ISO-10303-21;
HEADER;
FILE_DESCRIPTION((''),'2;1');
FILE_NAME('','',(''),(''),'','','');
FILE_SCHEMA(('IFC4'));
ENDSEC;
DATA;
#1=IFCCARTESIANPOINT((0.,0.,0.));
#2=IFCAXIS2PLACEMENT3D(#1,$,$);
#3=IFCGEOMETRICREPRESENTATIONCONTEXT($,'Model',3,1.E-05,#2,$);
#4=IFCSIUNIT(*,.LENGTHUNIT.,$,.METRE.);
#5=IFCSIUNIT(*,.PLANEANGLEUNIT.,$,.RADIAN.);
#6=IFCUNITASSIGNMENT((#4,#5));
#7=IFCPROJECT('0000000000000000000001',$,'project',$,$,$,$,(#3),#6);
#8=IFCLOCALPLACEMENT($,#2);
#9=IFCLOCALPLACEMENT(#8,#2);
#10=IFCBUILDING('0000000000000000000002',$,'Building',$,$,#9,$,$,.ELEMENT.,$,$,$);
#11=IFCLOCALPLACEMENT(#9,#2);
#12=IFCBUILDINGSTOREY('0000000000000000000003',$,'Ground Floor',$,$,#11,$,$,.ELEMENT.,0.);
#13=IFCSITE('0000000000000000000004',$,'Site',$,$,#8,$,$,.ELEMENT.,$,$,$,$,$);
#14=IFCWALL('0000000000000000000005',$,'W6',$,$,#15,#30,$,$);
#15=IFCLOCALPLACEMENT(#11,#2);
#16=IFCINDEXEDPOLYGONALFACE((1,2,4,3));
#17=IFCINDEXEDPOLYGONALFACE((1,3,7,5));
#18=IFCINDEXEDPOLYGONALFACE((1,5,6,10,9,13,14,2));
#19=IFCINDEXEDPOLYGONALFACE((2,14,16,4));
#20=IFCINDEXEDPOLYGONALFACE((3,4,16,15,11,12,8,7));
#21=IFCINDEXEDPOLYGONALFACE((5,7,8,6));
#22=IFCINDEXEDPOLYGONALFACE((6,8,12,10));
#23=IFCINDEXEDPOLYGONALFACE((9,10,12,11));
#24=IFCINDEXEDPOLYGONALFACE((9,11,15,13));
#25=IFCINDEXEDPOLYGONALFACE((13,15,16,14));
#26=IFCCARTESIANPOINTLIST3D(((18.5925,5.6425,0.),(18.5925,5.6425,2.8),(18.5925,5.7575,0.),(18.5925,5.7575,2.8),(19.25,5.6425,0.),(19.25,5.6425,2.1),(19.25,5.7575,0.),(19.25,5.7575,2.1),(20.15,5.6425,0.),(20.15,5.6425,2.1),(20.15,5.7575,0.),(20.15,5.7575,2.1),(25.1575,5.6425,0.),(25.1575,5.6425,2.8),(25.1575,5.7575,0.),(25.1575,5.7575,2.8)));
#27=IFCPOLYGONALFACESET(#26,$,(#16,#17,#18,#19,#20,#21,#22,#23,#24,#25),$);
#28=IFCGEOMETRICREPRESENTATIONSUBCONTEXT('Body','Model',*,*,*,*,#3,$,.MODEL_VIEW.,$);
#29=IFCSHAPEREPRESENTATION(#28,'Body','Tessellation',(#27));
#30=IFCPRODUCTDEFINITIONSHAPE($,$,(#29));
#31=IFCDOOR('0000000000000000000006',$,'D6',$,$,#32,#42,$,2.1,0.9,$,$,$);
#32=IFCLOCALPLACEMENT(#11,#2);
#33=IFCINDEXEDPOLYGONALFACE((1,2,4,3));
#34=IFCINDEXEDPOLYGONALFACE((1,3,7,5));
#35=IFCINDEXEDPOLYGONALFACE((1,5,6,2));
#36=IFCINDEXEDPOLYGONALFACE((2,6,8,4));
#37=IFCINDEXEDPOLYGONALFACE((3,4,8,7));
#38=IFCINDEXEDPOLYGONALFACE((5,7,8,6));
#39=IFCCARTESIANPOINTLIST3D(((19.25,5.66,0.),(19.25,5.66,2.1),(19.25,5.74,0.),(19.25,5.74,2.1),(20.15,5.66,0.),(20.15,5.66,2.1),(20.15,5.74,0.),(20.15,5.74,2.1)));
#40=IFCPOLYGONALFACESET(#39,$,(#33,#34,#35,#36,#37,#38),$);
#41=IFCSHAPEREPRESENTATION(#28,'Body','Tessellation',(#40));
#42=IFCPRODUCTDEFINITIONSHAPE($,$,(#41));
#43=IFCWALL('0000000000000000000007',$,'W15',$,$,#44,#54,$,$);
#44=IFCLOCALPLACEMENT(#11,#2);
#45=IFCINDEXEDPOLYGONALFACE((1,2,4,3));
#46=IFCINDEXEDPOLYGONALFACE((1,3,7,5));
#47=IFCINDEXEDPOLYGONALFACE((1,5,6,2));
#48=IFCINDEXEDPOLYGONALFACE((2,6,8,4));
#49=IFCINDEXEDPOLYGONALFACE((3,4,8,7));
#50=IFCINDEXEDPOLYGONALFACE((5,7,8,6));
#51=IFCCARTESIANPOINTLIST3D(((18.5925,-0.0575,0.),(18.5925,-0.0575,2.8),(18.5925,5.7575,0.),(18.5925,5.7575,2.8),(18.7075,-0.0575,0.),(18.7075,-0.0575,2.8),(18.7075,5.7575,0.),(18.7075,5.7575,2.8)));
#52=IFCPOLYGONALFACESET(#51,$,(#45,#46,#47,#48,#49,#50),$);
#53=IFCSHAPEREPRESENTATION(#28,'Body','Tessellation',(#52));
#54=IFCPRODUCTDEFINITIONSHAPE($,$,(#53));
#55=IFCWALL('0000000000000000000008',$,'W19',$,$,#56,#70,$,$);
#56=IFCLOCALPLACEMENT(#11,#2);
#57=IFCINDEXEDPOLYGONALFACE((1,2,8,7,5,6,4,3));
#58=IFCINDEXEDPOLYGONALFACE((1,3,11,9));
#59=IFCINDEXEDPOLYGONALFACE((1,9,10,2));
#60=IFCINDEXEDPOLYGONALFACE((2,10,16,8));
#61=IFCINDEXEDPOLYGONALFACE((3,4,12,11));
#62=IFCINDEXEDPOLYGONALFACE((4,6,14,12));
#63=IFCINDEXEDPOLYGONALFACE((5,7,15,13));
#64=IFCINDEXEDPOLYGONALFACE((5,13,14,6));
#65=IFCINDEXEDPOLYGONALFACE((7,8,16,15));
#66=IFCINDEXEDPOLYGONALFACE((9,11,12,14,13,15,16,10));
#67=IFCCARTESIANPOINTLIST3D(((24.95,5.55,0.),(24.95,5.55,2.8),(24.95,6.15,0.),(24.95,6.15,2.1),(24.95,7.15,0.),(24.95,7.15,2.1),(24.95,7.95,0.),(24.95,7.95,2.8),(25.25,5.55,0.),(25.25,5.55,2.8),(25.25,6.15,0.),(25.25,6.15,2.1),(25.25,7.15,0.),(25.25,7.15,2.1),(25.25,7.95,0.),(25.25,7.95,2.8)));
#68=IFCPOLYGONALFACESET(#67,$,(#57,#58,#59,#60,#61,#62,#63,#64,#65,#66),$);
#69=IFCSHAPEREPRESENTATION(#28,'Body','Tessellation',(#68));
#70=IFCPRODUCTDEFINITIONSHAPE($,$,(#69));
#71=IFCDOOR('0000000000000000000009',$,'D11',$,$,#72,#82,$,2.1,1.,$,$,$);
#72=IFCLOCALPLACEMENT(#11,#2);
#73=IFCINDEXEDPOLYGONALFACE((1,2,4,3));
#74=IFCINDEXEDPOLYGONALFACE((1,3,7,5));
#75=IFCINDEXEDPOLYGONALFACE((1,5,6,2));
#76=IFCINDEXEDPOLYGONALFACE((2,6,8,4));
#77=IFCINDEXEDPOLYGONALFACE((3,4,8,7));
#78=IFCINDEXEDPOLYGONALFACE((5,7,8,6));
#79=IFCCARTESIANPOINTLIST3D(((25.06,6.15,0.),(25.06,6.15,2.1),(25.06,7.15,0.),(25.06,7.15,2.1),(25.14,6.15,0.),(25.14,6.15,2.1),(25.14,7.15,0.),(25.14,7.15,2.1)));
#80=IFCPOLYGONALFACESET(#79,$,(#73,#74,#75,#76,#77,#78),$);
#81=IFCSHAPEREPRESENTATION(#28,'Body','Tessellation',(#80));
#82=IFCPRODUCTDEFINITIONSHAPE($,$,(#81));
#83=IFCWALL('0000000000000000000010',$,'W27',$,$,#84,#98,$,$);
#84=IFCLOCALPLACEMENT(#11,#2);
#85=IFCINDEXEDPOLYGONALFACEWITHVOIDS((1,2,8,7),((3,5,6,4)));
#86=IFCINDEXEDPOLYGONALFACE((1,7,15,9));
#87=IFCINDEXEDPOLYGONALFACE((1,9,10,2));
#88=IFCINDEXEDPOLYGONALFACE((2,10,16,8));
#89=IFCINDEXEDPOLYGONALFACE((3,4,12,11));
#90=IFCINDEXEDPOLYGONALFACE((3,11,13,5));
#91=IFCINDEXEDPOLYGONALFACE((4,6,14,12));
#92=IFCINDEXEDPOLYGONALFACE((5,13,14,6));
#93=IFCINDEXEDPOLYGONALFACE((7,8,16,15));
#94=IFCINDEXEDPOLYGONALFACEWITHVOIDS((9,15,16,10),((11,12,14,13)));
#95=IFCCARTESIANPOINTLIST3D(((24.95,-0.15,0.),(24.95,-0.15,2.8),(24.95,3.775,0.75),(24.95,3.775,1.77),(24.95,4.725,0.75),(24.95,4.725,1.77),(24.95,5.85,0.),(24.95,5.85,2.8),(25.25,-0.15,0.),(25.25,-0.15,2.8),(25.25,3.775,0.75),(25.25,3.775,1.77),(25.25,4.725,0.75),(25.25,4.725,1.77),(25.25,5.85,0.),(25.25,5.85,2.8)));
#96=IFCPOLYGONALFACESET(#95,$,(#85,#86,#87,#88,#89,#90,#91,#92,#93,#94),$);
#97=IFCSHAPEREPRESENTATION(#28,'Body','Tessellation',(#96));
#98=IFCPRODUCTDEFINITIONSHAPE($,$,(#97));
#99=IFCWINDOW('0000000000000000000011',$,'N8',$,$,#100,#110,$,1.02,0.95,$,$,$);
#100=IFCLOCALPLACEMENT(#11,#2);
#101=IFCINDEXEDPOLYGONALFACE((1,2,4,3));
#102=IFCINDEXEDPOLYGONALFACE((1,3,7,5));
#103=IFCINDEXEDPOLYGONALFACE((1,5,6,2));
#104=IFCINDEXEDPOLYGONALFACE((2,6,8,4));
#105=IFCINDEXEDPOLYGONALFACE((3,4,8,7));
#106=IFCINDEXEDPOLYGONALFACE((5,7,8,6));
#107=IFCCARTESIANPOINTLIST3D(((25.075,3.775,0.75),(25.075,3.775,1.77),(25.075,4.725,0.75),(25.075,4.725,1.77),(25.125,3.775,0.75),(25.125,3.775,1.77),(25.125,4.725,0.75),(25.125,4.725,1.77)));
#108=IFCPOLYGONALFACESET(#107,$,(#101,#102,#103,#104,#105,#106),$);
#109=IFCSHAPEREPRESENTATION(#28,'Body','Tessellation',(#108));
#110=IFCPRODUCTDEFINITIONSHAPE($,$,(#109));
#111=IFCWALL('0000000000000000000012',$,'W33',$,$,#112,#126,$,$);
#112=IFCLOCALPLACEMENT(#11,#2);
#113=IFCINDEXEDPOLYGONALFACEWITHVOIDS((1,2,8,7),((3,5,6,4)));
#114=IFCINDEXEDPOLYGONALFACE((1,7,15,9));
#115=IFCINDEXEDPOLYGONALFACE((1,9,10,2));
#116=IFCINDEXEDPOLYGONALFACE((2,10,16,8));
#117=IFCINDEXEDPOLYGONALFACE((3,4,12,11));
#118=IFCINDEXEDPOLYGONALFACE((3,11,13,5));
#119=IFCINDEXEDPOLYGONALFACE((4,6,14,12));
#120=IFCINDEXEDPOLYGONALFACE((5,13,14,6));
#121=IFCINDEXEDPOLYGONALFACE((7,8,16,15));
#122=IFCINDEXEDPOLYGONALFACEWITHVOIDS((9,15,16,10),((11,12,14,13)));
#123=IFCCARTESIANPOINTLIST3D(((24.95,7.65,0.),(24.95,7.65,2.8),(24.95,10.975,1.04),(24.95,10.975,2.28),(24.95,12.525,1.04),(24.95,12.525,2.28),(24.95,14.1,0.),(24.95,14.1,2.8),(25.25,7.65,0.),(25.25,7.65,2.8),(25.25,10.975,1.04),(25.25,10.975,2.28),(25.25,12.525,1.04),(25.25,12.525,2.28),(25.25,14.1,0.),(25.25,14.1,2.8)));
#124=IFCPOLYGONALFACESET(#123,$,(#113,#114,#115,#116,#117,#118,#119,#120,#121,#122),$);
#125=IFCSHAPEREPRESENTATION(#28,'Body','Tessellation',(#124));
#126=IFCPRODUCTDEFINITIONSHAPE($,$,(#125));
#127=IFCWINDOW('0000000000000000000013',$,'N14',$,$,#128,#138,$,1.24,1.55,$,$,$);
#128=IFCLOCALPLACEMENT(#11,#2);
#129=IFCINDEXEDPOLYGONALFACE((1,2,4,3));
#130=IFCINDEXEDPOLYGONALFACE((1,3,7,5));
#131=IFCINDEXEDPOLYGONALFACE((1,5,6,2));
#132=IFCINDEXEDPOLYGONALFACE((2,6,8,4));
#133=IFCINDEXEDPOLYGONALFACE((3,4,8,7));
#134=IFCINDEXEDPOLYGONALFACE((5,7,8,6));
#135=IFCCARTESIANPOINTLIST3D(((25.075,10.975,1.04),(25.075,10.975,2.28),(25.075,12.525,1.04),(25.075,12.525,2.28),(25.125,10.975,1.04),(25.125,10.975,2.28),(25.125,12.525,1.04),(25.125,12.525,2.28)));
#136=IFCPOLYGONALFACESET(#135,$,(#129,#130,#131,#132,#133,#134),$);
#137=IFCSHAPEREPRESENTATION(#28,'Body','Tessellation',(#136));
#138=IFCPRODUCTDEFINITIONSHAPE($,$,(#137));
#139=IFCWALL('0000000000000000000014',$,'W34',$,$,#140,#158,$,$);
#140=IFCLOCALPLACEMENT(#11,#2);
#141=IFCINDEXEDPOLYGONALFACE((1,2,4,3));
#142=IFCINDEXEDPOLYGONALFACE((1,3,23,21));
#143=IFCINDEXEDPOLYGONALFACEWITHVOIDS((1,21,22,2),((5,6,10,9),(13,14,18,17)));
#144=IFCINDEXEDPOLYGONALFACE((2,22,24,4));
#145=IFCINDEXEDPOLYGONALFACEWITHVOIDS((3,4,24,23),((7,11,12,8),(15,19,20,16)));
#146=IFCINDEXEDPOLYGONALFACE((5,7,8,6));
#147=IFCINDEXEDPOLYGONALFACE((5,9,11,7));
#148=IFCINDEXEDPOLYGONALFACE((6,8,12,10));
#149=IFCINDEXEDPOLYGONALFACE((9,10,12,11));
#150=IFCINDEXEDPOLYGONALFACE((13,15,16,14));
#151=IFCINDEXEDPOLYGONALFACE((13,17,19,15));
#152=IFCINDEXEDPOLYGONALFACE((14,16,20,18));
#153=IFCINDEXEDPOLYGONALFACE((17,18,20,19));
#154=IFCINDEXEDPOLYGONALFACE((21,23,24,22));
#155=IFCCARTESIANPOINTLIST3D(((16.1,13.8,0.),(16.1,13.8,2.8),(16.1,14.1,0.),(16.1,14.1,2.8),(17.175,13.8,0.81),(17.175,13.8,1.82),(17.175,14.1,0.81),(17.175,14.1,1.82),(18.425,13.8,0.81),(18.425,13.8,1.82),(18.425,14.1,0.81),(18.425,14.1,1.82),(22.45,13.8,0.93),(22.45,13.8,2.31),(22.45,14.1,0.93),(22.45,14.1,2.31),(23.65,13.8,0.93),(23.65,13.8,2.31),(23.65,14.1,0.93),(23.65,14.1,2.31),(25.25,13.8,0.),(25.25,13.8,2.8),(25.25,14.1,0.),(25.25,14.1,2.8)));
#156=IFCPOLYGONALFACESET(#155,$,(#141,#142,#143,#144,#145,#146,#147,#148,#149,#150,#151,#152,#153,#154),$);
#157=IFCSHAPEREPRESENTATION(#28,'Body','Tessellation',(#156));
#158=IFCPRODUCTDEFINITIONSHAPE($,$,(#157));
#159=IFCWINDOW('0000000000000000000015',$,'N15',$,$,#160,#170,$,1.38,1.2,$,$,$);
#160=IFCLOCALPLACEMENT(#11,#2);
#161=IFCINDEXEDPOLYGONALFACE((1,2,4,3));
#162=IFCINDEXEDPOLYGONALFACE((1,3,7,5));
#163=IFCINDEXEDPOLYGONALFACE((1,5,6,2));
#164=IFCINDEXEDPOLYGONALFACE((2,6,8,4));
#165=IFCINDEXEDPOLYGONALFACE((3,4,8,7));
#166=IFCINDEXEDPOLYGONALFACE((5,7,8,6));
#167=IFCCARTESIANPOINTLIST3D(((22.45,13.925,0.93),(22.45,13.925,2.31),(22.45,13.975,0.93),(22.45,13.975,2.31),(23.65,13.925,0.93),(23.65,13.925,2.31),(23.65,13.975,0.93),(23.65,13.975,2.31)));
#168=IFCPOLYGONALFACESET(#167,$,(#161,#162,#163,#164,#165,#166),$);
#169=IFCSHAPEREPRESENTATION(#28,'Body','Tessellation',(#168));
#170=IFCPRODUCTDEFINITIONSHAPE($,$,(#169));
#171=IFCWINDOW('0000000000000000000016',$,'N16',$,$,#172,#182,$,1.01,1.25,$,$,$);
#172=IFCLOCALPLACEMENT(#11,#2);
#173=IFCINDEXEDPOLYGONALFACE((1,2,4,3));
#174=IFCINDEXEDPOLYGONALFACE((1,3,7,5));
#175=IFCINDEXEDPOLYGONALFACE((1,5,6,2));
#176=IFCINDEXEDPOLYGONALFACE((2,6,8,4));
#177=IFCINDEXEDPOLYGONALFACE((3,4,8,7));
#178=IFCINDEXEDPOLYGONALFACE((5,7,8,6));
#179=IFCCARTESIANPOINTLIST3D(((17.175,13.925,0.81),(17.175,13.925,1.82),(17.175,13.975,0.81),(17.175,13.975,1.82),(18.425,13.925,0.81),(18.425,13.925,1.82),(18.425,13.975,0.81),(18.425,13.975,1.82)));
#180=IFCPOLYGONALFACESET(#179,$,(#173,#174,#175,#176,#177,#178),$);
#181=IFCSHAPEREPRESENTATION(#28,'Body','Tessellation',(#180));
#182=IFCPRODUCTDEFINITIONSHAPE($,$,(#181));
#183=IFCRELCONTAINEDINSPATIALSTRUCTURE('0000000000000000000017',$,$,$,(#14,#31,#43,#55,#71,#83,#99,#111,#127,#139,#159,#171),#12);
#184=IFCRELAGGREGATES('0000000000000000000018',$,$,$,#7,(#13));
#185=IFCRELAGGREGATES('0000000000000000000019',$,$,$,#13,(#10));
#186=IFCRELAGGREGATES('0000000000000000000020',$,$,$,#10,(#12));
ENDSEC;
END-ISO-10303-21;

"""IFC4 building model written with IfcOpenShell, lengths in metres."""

from ifc_helpers import new_model, si_unit, frame, frame_2d, origin, origin_2d, place, context, subcontext, project, spatial, rectangle, extrude, element, fill, save


model = new_model("IFC4")

# Units and contexts
model_context = context("Model", 3, precision=1e-05, world=origin())
body_context = subcontext(model_context, "Body", "Model", "MODEL_VIEW")
ifc_project = project(units=[si_unit("LENGTHUNIT", "METRE"), si_unit("PLANEANGLEUNIT", "RADIAN")], contexts=[model_context])

# Site, building, storey
site_placement = place(None, origin())
site = spatial("IfcSite", under=ifc_project, at=site_placement, Name="Site", CompositionType="ELEMENT")
building_placement = place(site_placement, origin())
building = spatial("IfcBuilding", under=site, at=building_placement, Name="Building", CompositionType="ELEMENT")
storey_placement = place(building_placement, origin())
storey = spatial("IfcBuildingStorey", under=building, at=storey_placement, Name="Ground Floor", CompositionType="ELEMENT", Elevation=0.0)

# Wall, opening, door
wall_1_placement = place(storey_placement, frame((18.65, 5.7, 0.0), x_axis=(1.0, 0.0, 0.0)))
wall_1 = element("IfcWall", 1, at=wall_1_placement, inside=storey, Name="W6", context=body_context, shape_type="SweptSolid", body=[
    extrude(rectangle(XDim=6.565, YDim=0.115, at=frame_2d((3.225, 0.0))), origin(), (0.0, 0.0, 1.0), 2.8),
])
opening_1_placement = place(wall_1_placement, frame((1.05, 0.0, 0.0)))
opening_1 = element("IfcOpeningElement", 2, at=opening_1_placement, cuts=wall_1, context=body_context, shape_type="SweptSolid", body=[
    extrude(rectangle(XDim=0.9, YDim=0.215, at=origin_2d()), origin(), (0.0, 0.0, 1.0), 2.1),
])
door_1_placement = place(opening_1_placement, origin())
door_1 = element("IfcDoor", 3, at=door_1_placement, inside=storey, Name="D6", OverallHeight=2.1, OverallWidth=0.9, context=body_context, shape_type="SweptSolid", body=[
    extrude(rectangle(XDim=0.9, YDim=0.08, at=origin_2d()), origin(), (0.0, 0.0, 1.0), 2.1),
])
fill(opening_1, door_1)

# Wall
wall_2_placement = place(storey_placement, frame((18.65, 0.0, 0.0), x_axis=(0.0, 1.0, 0.0)))
element("IfcWall", 4, at=wall_2_placement, inside=storey, Name="W15", context=body_context, shape_type="SweptSolid", body=[
    extrude(rectangle(XDim=5.815, YDim=0.115, at=frame_2d((2.85, 0.0))), origin(), (0.0, 0.0, 1.0), 2.8),
])

# Wall, opening, door
wall_3_placement = place(storey_placement, frame((25.1, 5.7, 0.0), x_axis=(0.0, 1.0, 0.0)))
wall_3 = element("IfcWall", 5, at=wall_3_placement, inside=storey, Name="W19", context=body_context, shape_type="SweptSolid", body=[
    extrude(rectangle(XDim=2.4, YDim=0.3, at=frame_2d((1.05, 0.0))), origin(), (0.0, 0.0, 1.0), 2.8),
])
opening_2_placement = place(wall_3_placement, frame((0.95, 0.0, 0.0)))
opening_2 = element("IfcOpeningElement", 6, at=opening_2_placement, cuts=wall_3, context=body_context, shape_type="SweptSolid", body=[
    extrude(rectangle(XDim=1.0, YDim=0.4, at=origin_2d()), origin(), (0.0, 0.0, 1.0), 2.1),
])
door_2_placement = place(opening_2_placement, origin())
door_2 = element("IfcDoor", 7, at=door_2_placement, inside=storey, Name="D11", OverallHeight=2.1, OverallWidth=1.0, context=body_context, shape_type="SweptSolid", body=[
    extrude(rectangle(XDim=1.0, YDim=0.08, at=origin_2d()), origin(), (0.0, 0.0, 1.0), 2.1),
])
fill(opening_2, door_2)

# Walls, openings, windows
wall_4_placement = place(storey_placement, frame((25.1, 0.0, 0.0), x_axis=(0.0, 1.0, 0.0)))
wall_4 = element("IfcWall", 8, at=wall_4_placement, inside=storey, Name="W27", context=body_context, shape_type="SweptSolid", body=[
    extrude(rectangle(XDim=6.0, YDim=0.3, at=frame_2d((2.85, 0.0))), origin(), (0.0, 0.0, 1.0), 2.8),
])
opening_3_placement = place(wall_4_placement, frame((4.25, 0.0, 0.75)))
opening_3 = element("IfcOpeningElement", 9, at=opening_3_placement, cuts=wall_4, context=body_context, shape_type="SweptSolid", body=[
    extrude(rectangle(XDim=0.95, YDim=0.4, at=origin_2d()), origin(), (0.0, 0.0, 1.0), 1.02),
])
window_1_placement = place(opening_3_placement, origin())
window_1 = element("IfcWindow", 10, at=window_1_placement, inside=storey, Name="N8", OverallHeight=1.02, OverallWidth=0.95, context=body_context, shape_type="SweptSolid", body=[
    extrude(rectangle(XDim=0.95, YDim=0.05, at=origin_2d()), origin(), (0.0, 0.0, 1.0), 1.02),
])
fill(opening_3, window_1)
wall_5_placement = place(storey_placement, frame((25.1, 7.8, 0.0), x_axis=(0.0, 1.0, 0.0)))
wall_5 = element("IfcWall", 11, at=wall_5_placement, inside=storey, Name="W33", context=body_context, shape_type="SweptSolid", body=[
    extrude(rectangle(XDim=6.45, YDim=0.3, at=frame_2d((3.075, 0.0))), origin(), (0.0, 0.0, 1.0), 2.8),
])
opening_4_placement = place(wall_5_placement, frame((3.95, 0.0, 1.04)))
opening_4 = element("IfcOpeningElement", 12, at=opening_4_placement, cuts=wall_5, context=body_context, shape_type="SweptSolid", body=[
    extrude(rectangle(XDim=1.55, YDim=0.4, at=origin_2d()), origin(), (0.0, 0.0, 1.0), 1.24),
])
window_2_placement = place(opening_4_placement, origin())
window_2 = element("IfcWindow", 13, at=window_2_placement, inside=storey, Name="N14", OverallHeight=1.24, OverallWidth=1.55, context=body_context, shape_type="SweptSolid", body=[
    extrude(rectangle(XDim=1.55, YDim=0.05, at=origin_2d()), origin(), (0.0, 0.0, 1.0), 1.24),
])
fill(opening_4, window_2)

# Wall, openings, windows
wall_6_placement = place(storey_placement, frame((16.25, 13.95, 0.0), x_axis=(1.0, 0.0, 0.0)))
wall_6 = element("IfcWall", 14, at=wall_6_placement, inside=storey, Name="W34", context=body_context, shape_type="SweptSolid", body=[
    extrude(rectangle(XDim=9.15, YDim=0.3, at=frame_2d((4.425, 0.0))), origin(), (0.0, 0.0, 1.0), 2.8),
])
opening_5_placement = place(wall_6_placement, frame((6.8, 0.0, 0.93)))
opening_5 = element("IfcOpeningElement", 15, at=opening_5_placement, cuts=wall_6, context=body_context, shape_type="SweptSolid", body=[
    extrude(rectangle(XDim=1.2, YDim=0.4, at=origin_2d()), origin(), (0.0, 0.0, 1.0), 1.38),
])
opening_6_placement = place(wall_6_placement, frame((1.55, 0.0, 0.81)))
opening_6 = element("IfcOpeningElement", 16, at=opening_6_placement, cuts=wall_6, context=body_context, shape_type="SweptSolid", body=[
    extrude(rectangle(XDim=1.25, YDim=0.4, at=origin_2d()), origin(), (0.0, 0.0, 1.0), 1.01),
])
window_3_placement = place(opening_5_placement, origin())
window_3 = element("IfcWindow", 17, at=window_3_placement, inside=storey, Name="N15", OverallHeight=1.38, OverallWidth=1.2, context=body_context, shape_type="SweptSolid", body=[
    extrude(rectangle(XDim=1.2, YDim=0.05, at=origin_2d()), origin(), (0.0, 0.0, 1.0), 1.38),
])
fill(opening_5, window_3)
window_4_placement = place(opening_6_placement, origin())
window_4 = element("IfcWindow", 18, at=window_4_placement, inside=storey, Name="N16", OverallHeight=1.01, OverallWidth=1.25, context=body_context, shape_type="SweptSolid", body=[
    extrude(rectangle(XDim=1.25, YDim=0.05, at=origin_2d()), origin(), (0.0, 0.0, 1.0), 1.01),
])
fill(opening_6, window_4)

save(model, "model.ifc")
